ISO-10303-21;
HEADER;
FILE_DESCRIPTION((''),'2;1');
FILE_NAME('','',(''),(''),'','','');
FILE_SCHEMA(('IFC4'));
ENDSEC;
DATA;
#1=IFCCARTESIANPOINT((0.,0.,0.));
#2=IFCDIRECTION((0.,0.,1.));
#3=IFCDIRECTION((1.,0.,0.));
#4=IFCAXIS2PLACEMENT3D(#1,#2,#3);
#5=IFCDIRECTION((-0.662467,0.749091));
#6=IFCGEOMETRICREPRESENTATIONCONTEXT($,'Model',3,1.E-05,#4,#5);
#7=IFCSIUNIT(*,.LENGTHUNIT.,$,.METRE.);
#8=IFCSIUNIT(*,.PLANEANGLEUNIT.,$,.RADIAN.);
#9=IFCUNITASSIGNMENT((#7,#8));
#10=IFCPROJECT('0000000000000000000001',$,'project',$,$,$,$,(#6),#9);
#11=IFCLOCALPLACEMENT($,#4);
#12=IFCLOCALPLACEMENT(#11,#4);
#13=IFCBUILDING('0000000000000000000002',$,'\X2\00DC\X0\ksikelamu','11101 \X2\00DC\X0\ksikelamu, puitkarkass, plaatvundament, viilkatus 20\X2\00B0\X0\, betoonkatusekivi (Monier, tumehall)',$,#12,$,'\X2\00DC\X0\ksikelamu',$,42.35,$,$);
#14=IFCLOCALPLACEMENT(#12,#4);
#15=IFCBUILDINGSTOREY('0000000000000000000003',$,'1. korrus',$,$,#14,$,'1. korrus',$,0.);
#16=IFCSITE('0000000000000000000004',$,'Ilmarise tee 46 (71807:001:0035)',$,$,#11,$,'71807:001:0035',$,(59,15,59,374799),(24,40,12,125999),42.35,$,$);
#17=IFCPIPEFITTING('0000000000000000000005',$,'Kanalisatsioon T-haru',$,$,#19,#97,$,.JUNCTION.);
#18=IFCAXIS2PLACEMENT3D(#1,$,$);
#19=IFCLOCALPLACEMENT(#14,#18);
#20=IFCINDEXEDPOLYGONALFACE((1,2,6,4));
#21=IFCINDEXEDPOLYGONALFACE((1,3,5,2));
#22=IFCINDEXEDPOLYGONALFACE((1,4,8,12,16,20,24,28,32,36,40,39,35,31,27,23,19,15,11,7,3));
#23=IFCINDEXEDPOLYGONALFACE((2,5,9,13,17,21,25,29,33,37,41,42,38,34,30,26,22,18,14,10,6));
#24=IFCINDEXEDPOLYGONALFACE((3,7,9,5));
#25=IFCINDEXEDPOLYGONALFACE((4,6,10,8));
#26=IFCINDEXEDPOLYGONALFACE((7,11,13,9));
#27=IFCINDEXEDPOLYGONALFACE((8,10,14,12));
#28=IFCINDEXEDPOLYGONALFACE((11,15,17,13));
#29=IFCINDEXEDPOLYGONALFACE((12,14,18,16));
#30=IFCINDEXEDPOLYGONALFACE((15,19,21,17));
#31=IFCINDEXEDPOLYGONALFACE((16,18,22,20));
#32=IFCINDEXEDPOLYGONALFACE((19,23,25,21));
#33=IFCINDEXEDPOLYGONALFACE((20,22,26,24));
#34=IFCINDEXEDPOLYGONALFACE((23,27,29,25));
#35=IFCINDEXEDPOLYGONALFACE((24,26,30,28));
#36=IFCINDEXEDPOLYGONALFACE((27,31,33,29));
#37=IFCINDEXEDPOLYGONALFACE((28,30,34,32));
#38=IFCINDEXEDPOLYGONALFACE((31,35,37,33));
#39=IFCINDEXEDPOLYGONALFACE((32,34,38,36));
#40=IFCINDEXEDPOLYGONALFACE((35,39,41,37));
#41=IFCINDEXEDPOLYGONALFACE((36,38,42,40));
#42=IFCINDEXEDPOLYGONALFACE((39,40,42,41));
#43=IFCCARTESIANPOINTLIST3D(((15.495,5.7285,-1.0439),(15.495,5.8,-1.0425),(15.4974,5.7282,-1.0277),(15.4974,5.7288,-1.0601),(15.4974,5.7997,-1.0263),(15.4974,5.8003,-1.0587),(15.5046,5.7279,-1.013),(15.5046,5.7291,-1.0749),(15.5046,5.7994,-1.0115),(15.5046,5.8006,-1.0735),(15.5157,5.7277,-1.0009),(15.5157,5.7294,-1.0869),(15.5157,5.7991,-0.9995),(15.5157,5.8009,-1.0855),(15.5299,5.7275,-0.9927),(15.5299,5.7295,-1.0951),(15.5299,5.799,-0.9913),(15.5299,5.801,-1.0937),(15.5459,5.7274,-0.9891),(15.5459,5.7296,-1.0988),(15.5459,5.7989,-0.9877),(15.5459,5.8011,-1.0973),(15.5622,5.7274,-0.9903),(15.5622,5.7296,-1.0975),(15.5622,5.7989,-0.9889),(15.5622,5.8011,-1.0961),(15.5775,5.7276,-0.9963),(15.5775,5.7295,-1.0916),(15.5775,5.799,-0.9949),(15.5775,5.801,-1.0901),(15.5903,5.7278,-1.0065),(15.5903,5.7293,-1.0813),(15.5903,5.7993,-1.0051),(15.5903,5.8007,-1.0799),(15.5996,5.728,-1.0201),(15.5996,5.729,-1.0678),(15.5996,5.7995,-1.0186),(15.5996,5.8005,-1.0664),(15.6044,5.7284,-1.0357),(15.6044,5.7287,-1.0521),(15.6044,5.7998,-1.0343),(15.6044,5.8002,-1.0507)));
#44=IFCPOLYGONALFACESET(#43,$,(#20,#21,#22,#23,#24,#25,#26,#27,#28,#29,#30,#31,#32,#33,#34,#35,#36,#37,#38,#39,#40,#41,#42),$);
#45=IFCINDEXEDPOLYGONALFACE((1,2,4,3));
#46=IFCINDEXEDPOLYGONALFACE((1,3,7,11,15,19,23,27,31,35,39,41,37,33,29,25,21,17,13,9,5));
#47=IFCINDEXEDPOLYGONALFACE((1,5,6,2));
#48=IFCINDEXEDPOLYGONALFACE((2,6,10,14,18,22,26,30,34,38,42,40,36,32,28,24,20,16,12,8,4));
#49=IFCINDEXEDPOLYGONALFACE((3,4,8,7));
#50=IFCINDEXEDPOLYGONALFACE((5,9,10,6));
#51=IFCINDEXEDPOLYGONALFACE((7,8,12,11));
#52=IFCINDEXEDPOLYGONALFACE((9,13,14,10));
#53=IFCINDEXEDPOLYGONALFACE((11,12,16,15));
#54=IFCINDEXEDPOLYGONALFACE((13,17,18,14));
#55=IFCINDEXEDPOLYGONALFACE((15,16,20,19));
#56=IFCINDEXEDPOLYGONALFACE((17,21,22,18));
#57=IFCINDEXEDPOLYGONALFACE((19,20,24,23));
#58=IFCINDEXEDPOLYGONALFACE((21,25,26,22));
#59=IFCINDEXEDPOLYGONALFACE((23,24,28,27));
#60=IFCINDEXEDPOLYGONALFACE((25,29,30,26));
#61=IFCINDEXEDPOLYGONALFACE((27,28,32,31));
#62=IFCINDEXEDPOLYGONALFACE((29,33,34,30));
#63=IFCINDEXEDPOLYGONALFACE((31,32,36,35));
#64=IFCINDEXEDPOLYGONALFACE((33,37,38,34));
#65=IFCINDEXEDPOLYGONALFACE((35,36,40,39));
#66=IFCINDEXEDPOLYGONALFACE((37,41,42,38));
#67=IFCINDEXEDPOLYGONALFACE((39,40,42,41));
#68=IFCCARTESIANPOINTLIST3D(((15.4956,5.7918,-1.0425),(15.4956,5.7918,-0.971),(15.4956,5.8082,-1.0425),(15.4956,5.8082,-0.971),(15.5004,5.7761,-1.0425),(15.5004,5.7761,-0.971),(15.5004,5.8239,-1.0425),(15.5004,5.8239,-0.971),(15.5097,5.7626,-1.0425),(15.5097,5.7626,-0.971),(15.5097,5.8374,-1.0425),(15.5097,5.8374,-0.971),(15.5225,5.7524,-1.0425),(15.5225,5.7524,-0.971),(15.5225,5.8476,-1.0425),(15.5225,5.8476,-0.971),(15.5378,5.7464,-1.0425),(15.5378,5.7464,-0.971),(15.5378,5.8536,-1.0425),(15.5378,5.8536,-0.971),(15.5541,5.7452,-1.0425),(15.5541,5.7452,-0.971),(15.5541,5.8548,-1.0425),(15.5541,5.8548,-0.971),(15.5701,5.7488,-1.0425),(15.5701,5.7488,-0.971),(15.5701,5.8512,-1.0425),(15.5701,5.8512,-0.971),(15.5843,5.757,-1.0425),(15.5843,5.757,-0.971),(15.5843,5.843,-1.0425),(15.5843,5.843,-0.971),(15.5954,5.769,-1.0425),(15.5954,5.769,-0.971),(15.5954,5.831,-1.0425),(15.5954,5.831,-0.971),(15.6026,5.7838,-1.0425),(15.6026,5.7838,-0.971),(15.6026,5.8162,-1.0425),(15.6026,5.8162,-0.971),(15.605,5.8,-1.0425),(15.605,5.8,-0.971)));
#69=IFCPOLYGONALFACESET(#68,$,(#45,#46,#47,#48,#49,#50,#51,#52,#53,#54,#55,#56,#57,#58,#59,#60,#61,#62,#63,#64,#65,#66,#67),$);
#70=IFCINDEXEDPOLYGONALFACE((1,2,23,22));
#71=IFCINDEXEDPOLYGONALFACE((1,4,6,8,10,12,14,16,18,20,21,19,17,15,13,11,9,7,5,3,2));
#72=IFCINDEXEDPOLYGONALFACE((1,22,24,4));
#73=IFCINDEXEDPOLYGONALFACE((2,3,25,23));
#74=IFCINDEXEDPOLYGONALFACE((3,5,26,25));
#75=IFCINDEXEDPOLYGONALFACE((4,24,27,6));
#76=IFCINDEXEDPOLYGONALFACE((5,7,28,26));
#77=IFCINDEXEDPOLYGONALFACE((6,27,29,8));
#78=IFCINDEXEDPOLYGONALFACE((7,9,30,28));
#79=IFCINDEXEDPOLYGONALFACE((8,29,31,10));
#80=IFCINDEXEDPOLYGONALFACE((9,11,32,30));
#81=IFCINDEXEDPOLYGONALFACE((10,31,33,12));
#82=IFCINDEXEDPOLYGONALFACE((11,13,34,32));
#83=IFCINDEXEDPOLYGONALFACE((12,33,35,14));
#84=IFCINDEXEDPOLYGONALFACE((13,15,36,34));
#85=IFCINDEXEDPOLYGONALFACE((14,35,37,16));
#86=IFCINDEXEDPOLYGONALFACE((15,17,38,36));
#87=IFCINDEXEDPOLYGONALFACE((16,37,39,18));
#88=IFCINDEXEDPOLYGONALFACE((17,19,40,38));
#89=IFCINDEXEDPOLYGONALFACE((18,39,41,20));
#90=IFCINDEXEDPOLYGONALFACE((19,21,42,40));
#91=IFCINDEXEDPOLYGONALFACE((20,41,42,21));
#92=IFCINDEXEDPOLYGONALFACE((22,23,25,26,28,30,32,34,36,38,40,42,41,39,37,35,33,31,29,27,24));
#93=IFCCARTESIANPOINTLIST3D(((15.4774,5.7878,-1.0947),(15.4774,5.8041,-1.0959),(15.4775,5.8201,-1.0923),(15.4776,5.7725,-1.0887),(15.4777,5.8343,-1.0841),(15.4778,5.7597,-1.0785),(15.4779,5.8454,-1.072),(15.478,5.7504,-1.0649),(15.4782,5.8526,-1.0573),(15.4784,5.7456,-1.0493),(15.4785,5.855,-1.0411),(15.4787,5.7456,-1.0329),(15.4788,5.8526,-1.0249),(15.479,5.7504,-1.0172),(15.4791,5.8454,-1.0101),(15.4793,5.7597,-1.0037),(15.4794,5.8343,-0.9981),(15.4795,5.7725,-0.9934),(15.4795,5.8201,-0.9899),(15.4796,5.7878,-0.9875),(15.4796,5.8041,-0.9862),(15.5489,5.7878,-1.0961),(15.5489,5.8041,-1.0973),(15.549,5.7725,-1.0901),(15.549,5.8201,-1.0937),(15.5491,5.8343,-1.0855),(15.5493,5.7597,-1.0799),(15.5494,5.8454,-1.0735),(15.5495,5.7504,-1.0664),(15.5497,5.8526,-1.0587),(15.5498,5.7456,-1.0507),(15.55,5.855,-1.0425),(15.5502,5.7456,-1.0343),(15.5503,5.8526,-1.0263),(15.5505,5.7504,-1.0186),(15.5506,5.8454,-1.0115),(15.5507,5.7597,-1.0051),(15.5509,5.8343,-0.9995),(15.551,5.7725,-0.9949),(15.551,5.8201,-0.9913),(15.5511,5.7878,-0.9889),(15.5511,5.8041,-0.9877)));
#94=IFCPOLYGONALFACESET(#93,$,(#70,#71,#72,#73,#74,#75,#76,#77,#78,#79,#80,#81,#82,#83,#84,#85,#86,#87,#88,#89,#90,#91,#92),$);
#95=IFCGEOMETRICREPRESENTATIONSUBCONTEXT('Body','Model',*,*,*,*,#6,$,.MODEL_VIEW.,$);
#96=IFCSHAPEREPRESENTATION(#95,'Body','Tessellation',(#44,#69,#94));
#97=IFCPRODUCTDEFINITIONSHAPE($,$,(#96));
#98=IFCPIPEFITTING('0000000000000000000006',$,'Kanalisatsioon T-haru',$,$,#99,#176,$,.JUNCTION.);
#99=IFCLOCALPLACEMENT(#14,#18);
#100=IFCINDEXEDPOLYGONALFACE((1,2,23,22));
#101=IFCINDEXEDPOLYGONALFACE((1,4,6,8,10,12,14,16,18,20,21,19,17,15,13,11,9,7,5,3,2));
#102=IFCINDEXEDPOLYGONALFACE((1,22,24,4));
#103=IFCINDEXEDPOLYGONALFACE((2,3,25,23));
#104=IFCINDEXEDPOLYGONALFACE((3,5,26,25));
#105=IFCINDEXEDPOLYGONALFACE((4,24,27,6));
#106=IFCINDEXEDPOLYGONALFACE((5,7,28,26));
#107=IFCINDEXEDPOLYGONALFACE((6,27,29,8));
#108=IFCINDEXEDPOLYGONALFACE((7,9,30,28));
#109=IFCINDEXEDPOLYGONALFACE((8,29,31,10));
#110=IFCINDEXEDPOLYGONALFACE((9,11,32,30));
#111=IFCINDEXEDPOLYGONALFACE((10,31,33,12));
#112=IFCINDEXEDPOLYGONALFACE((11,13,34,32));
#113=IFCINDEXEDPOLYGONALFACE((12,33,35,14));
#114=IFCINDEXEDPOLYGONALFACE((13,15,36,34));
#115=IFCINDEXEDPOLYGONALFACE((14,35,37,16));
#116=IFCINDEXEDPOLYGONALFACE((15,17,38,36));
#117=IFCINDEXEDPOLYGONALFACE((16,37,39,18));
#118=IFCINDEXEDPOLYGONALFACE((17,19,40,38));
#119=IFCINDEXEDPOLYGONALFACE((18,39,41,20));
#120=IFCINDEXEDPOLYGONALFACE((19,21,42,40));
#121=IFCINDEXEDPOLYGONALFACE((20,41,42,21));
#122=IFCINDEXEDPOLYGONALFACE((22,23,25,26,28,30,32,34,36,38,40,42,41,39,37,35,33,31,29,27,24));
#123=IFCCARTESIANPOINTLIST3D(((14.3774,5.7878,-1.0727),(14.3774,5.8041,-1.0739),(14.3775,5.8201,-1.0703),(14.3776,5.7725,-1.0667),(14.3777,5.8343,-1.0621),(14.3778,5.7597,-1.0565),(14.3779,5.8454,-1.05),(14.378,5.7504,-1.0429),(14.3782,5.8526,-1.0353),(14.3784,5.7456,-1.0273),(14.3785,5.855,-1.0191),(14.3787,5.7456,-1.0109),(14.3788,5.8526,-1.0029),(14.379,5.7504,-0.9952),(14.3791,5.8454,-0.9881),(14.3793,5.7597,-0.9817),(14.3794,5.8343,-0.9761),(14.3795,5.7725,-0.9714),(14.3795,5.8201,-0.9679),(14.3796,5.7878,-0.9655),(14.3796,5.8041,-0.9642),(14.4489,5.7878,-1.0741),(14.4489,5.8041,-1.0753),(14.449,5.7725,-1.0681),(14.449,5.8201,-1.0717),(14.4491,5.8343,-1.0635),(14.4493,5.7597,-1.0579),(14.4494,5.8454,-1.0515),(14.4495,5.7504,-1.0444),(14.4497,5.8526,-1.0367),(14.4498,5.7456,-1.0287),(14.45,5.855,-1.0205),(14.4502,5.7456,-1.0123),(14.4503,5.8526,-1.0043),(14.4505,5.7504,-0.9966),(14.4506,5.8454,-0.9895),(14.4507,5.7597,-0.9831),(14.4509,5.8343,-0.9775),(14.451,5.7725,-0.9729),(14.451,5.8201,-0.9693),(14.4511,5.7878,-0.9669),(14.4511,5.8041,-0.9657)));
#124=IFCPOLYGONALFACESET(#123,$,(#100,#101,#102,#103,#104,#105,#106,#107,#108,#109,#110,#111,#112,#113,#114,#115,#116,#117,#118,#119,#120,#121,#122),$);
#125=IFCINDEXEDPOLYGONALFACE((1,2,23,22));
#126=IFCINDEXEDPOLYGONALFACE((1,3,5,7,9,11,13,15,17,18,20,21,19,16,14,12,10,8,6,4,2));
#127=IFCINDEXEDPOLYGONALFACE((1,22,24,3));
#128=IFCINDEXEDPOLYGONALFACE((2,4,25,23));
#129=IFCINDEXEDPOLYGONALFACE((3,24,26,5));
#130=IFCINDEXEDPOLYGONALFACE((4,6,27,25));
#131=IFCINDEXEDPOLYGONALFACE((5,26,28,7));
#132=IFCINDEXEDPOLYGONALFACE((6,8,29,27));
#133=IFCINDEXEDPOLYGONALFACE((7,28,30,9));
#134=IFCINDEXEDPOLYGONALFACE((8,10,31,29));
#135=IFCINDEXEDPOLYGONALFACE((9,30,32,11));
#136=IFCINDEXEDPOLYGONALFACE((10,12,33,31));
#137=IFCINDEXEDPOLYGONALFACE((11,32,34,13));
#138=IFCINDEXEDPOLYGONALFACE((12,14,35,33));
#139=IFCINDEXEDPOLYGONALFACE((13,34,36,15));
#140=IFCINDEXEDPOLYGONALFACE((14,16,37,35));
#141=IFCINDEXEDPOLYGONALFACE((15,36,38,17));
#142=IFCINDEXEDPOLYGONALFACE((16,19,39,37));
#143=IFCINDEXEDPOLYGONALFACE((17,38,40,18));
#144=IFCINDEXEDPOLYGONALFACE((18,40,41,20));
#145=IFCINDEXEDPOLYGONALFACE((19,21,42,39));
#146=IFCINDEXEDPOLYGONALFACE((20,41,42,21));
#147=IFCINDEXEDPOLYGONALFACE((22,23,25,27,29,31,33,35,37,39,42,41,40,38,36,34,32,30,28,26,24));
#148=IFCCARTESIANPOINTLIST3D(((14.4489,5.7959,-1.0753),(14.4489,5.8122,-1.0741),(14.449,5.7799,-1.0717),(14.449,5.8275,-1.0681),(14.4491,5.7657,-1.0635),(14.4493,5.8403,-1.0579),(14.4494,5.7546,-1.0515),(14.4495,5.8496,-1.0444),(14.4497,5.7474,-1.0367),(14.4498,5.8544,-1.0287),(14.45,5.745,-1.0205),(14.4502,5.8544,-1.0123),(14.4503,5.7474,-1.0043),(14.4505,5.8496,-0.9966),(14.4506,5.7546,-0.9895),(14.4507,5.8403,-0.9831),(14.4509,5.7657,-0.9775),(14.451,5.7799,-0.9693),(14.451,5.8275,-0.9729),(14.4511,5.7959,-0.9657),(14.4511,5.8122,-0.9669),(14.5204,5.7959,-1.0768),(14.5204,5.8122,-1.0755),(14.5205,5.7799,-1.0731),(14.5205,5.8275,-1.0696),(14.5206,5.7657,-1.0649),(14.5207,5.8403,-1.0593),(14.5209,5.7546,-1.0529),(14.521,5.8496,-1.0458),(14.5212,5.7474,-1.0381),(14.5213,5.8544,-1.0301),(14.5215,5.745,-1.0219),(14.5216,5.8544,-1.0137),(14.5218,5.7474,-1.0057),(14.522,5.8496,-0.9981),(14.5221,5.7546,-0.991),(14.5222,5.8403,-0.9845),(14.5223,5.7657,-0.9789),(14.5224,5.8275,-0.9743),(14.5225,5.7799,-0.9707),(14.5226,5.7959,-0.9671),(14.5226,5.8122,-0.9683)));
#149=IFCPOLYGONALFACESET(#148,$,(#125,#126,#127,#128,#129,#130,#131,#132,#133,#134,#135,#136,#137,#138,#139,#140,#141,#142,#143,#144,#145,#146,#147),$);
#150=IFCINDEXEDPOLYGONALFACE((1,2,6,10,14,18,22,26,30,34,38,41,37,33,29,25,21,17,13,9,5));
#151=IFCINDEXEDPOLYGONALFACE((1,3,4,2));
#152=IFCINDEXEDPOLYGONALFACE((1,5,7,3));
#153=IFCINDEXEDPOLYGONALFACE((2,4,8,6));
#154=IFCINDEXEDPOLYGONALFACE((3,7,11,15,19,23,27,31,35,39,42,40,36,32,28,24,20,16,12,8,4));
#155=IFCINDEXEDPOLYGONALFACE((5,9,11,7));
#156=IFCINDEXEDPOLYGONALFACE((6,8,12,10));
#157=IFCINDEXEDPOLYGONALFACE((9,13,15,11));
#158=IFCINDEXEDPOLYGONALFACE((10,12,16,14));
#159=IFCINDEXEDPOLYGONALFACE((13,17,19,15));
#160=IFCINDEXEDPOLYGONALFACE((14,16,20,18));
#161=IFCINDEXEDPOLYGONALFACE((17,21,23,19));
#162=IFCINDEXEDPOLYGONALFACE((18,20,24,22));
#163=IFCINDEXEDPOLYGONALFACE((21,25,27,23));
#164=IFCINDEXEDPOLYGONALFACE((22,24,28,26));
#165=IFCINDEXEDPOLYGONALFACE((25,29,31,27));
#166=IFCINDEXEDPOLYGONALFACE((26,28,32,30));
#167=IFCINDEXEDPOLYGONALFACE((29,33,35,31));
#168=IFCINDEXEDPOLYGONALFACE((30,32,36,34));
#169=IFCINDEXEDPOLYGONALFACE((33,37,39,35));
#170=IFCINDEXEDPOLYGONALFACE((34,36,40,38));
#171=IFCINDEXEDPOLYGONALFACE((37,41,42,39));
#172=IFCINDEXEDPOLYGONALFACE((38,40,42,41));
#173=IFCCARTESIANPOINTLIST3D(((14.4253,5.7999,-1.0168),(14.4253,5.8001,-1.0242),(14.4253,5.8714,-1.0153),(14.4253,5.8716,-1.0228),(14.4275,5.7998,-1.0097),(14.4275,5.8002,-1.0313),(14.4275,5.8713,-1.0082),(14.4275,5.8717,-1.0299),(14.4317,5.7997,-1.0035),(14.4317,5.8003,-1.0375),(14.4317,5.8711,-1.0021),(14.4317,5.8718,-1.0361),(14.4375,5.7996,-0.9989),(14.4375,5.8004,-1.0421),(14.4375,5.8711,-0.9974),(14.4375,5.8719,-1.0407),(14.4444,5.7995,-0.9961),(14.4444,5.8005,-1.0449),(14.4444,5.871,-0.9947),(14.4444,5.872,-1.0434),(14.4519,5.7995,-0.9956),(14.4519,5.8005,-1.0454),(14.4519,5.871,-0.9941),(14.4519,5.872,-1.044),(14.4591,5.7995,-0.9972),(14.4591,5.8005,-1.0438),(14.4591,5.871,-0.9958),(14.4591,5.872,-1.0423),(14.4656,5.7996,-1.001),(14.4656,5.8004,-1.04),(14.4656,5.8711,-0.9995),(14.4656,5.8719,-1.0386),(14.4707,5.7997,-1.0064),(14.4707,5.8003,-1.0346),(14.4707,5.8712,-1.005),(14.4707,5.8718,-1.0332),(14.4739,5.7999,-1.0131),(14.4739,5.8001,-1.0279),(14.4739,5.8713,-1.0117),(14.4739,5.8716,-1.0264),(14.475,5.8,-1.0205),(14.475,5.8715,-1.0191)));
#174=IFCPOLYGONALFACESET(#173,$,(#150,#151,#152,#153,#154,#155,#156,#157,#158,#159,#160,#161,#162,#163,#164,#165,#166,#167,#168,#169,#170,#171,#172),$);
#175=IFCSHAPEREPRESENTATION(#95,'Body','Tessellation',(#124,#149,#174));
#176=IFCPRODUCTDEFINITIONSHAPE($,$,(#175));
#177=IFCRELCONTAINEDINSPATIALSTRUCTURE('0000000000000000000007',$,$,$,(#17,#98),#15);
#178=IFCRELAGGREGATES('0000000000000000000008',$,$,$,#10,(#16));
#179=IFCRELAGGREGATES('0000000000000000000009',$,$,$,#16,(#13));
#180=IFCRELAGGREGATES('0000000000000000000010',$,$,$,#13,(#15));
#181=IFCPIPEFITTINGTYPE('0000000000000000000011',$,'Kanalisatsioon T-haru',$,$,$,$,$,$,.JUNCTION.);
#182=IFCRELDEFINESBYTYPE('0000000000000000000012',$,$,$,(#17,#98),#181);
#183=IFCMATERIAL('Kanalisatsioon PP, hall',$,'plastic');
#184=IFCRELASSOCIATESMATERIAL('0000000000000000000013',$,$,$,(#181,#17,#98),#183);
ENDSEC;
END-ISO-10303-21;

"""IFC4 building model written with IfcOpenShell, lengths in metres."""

from ifc_helpers import new_model, si_unit, direction, frame, origin_with_axes, place, context, subcontext, project, spatial, circle, extrude, material, type_object, element, save


model = new_model("IFC4")

# Units and contexts
model_context = context("Model", 3, precision=1e-05, world=origin_with_axes(), true_north=direction((-0.662467, 0.749091)))
body_context = subcontext(model_context, "Body", "Model", "MODEL_VIEW")
ifc_project = project(units=[si_unit("LENGTHUNIT", "METRE"), si_unit("PLANEANGLEUNIT", "RADIAN")], contexts=[model_context])

# Site, building, storey
site_placement = place(None, origin_with_axes())
site = spatial("IfcSite", under=ifc_project, at=site_placement, Name="Ilmarise tee 46 (71807:001:0035)", LongName="71807:001:0035", RefLatitude=(59, 15, 59, 374799), RefLongitude=(24, 40, 12, 125999), RefElevation=42.35)
building_placement = place(site_placement, origin_with_axes())
building = spatial("IfcBuilding", under=site, at=building_placement, Name="Üksikelamu", Description="11101 Üksikelamu, puitkarkass, plaatvundament, viilkatus 20°, betoonkatusekivi (Monier, tumehall)", LongName="Üksikelamu", ElevationOfRefHeight=42.35)
storey_placement = place(building_placement, origin_with_axes())
storey = spatial("IfcBuildingStorey", under=building, at=storey_placement, Name="1. korrus", LongName="1. korrus", Elevation=0.0)

# Pipe fittings
ifc_material_1 = material(Name="Kanalisatsioon PP, hall", Category="plastic")
pipe_fitting_type_1 = type_object("IfcPipeFittingType", Name="Kanalisatsioon T-haru", PredefinedType="JUNCTION", material=ifc_material_1)
pipe_fitting_1_placement = place(storey_placement, frame((15.55, 5.8, -1.0425), z_axis=(0.0, 0.0, 1.0), x_axis=(1.0, 0.0, 0.0)))
element("IfcPipeFitting", 1, at=pipe_fitting_1_placement, inside=storey, type_object=pipe_fitting_type_1, material=ifc_material_1, Name="Kanalisatsioon T-haru", PredefinedType="JUNCTION", context=body_context, shape_type="SweptSolid", body=[
    extrude(circle(Radius=0.055), frame((0.0, 0.0, 0.0), z_axis=(0.0, -0.9998, -0.019996), x_axis=(-1.0, 0.0, 0.0)), (0.0, 0.0, 1.0), 0.0715),
    extrude(circle(Radius=0.055), origin_with_axes(), (0.0, 0.0, 1.0), 0.0715),
    extrude(circle(Radius=0.055), frame((0.0, 0.0, 0.0), z_axis=(-0.9998, 0.0, 0.019996), x_axis=(0.0, 1.0, 0.0)), (0.0, 0.0, 1.0), 0.0715),
])
pipe_fitting_2_placement = place(storey_placement, frame((14.45, 5.8, -1.0205), z_axis=(0.0, 0.0, 1.0), x_axis=(1.0, 0.0, 0.0)))
element("IfcPipeFitting", 2, at=pipe_fitting_2_placement, inside=storey, type_object=pipe_fitting_type_1, material=ifc_material_1, Name="Kanalisatsioon T-haru", PredefinedType="JUNCTION", context=body_context, shape_type="SweptSolid", body=[
    extrude(circle(Radius=0.055), frame((0.0, 0.0, 0.0), z_axis=(-0.9998, 0.0, 0.019996), x_axis=(0.0, 1.0, 0.0)), (0.0, 0.0, 1.0), 0.0715),
    extrude(circle(Radius=0.055), frame((0.0, 0.0, 0.0), z_axis=(0.9998, 0.0, -0.019996), x_axis=(0.0, -1.0, 0.0)), (0.0, 0.0, 1.0), 0.0715),
    extrude(circle(Radius=0.025), frame((0.0, 0.0, 0.0), z_axis=(0.0, 0.9998, 0.019996), x_axis=(1.0, 0.0, 0.0)), (0.0, 0.0, 1.0), 0.0715),
])

save(model, "model.ifc")
